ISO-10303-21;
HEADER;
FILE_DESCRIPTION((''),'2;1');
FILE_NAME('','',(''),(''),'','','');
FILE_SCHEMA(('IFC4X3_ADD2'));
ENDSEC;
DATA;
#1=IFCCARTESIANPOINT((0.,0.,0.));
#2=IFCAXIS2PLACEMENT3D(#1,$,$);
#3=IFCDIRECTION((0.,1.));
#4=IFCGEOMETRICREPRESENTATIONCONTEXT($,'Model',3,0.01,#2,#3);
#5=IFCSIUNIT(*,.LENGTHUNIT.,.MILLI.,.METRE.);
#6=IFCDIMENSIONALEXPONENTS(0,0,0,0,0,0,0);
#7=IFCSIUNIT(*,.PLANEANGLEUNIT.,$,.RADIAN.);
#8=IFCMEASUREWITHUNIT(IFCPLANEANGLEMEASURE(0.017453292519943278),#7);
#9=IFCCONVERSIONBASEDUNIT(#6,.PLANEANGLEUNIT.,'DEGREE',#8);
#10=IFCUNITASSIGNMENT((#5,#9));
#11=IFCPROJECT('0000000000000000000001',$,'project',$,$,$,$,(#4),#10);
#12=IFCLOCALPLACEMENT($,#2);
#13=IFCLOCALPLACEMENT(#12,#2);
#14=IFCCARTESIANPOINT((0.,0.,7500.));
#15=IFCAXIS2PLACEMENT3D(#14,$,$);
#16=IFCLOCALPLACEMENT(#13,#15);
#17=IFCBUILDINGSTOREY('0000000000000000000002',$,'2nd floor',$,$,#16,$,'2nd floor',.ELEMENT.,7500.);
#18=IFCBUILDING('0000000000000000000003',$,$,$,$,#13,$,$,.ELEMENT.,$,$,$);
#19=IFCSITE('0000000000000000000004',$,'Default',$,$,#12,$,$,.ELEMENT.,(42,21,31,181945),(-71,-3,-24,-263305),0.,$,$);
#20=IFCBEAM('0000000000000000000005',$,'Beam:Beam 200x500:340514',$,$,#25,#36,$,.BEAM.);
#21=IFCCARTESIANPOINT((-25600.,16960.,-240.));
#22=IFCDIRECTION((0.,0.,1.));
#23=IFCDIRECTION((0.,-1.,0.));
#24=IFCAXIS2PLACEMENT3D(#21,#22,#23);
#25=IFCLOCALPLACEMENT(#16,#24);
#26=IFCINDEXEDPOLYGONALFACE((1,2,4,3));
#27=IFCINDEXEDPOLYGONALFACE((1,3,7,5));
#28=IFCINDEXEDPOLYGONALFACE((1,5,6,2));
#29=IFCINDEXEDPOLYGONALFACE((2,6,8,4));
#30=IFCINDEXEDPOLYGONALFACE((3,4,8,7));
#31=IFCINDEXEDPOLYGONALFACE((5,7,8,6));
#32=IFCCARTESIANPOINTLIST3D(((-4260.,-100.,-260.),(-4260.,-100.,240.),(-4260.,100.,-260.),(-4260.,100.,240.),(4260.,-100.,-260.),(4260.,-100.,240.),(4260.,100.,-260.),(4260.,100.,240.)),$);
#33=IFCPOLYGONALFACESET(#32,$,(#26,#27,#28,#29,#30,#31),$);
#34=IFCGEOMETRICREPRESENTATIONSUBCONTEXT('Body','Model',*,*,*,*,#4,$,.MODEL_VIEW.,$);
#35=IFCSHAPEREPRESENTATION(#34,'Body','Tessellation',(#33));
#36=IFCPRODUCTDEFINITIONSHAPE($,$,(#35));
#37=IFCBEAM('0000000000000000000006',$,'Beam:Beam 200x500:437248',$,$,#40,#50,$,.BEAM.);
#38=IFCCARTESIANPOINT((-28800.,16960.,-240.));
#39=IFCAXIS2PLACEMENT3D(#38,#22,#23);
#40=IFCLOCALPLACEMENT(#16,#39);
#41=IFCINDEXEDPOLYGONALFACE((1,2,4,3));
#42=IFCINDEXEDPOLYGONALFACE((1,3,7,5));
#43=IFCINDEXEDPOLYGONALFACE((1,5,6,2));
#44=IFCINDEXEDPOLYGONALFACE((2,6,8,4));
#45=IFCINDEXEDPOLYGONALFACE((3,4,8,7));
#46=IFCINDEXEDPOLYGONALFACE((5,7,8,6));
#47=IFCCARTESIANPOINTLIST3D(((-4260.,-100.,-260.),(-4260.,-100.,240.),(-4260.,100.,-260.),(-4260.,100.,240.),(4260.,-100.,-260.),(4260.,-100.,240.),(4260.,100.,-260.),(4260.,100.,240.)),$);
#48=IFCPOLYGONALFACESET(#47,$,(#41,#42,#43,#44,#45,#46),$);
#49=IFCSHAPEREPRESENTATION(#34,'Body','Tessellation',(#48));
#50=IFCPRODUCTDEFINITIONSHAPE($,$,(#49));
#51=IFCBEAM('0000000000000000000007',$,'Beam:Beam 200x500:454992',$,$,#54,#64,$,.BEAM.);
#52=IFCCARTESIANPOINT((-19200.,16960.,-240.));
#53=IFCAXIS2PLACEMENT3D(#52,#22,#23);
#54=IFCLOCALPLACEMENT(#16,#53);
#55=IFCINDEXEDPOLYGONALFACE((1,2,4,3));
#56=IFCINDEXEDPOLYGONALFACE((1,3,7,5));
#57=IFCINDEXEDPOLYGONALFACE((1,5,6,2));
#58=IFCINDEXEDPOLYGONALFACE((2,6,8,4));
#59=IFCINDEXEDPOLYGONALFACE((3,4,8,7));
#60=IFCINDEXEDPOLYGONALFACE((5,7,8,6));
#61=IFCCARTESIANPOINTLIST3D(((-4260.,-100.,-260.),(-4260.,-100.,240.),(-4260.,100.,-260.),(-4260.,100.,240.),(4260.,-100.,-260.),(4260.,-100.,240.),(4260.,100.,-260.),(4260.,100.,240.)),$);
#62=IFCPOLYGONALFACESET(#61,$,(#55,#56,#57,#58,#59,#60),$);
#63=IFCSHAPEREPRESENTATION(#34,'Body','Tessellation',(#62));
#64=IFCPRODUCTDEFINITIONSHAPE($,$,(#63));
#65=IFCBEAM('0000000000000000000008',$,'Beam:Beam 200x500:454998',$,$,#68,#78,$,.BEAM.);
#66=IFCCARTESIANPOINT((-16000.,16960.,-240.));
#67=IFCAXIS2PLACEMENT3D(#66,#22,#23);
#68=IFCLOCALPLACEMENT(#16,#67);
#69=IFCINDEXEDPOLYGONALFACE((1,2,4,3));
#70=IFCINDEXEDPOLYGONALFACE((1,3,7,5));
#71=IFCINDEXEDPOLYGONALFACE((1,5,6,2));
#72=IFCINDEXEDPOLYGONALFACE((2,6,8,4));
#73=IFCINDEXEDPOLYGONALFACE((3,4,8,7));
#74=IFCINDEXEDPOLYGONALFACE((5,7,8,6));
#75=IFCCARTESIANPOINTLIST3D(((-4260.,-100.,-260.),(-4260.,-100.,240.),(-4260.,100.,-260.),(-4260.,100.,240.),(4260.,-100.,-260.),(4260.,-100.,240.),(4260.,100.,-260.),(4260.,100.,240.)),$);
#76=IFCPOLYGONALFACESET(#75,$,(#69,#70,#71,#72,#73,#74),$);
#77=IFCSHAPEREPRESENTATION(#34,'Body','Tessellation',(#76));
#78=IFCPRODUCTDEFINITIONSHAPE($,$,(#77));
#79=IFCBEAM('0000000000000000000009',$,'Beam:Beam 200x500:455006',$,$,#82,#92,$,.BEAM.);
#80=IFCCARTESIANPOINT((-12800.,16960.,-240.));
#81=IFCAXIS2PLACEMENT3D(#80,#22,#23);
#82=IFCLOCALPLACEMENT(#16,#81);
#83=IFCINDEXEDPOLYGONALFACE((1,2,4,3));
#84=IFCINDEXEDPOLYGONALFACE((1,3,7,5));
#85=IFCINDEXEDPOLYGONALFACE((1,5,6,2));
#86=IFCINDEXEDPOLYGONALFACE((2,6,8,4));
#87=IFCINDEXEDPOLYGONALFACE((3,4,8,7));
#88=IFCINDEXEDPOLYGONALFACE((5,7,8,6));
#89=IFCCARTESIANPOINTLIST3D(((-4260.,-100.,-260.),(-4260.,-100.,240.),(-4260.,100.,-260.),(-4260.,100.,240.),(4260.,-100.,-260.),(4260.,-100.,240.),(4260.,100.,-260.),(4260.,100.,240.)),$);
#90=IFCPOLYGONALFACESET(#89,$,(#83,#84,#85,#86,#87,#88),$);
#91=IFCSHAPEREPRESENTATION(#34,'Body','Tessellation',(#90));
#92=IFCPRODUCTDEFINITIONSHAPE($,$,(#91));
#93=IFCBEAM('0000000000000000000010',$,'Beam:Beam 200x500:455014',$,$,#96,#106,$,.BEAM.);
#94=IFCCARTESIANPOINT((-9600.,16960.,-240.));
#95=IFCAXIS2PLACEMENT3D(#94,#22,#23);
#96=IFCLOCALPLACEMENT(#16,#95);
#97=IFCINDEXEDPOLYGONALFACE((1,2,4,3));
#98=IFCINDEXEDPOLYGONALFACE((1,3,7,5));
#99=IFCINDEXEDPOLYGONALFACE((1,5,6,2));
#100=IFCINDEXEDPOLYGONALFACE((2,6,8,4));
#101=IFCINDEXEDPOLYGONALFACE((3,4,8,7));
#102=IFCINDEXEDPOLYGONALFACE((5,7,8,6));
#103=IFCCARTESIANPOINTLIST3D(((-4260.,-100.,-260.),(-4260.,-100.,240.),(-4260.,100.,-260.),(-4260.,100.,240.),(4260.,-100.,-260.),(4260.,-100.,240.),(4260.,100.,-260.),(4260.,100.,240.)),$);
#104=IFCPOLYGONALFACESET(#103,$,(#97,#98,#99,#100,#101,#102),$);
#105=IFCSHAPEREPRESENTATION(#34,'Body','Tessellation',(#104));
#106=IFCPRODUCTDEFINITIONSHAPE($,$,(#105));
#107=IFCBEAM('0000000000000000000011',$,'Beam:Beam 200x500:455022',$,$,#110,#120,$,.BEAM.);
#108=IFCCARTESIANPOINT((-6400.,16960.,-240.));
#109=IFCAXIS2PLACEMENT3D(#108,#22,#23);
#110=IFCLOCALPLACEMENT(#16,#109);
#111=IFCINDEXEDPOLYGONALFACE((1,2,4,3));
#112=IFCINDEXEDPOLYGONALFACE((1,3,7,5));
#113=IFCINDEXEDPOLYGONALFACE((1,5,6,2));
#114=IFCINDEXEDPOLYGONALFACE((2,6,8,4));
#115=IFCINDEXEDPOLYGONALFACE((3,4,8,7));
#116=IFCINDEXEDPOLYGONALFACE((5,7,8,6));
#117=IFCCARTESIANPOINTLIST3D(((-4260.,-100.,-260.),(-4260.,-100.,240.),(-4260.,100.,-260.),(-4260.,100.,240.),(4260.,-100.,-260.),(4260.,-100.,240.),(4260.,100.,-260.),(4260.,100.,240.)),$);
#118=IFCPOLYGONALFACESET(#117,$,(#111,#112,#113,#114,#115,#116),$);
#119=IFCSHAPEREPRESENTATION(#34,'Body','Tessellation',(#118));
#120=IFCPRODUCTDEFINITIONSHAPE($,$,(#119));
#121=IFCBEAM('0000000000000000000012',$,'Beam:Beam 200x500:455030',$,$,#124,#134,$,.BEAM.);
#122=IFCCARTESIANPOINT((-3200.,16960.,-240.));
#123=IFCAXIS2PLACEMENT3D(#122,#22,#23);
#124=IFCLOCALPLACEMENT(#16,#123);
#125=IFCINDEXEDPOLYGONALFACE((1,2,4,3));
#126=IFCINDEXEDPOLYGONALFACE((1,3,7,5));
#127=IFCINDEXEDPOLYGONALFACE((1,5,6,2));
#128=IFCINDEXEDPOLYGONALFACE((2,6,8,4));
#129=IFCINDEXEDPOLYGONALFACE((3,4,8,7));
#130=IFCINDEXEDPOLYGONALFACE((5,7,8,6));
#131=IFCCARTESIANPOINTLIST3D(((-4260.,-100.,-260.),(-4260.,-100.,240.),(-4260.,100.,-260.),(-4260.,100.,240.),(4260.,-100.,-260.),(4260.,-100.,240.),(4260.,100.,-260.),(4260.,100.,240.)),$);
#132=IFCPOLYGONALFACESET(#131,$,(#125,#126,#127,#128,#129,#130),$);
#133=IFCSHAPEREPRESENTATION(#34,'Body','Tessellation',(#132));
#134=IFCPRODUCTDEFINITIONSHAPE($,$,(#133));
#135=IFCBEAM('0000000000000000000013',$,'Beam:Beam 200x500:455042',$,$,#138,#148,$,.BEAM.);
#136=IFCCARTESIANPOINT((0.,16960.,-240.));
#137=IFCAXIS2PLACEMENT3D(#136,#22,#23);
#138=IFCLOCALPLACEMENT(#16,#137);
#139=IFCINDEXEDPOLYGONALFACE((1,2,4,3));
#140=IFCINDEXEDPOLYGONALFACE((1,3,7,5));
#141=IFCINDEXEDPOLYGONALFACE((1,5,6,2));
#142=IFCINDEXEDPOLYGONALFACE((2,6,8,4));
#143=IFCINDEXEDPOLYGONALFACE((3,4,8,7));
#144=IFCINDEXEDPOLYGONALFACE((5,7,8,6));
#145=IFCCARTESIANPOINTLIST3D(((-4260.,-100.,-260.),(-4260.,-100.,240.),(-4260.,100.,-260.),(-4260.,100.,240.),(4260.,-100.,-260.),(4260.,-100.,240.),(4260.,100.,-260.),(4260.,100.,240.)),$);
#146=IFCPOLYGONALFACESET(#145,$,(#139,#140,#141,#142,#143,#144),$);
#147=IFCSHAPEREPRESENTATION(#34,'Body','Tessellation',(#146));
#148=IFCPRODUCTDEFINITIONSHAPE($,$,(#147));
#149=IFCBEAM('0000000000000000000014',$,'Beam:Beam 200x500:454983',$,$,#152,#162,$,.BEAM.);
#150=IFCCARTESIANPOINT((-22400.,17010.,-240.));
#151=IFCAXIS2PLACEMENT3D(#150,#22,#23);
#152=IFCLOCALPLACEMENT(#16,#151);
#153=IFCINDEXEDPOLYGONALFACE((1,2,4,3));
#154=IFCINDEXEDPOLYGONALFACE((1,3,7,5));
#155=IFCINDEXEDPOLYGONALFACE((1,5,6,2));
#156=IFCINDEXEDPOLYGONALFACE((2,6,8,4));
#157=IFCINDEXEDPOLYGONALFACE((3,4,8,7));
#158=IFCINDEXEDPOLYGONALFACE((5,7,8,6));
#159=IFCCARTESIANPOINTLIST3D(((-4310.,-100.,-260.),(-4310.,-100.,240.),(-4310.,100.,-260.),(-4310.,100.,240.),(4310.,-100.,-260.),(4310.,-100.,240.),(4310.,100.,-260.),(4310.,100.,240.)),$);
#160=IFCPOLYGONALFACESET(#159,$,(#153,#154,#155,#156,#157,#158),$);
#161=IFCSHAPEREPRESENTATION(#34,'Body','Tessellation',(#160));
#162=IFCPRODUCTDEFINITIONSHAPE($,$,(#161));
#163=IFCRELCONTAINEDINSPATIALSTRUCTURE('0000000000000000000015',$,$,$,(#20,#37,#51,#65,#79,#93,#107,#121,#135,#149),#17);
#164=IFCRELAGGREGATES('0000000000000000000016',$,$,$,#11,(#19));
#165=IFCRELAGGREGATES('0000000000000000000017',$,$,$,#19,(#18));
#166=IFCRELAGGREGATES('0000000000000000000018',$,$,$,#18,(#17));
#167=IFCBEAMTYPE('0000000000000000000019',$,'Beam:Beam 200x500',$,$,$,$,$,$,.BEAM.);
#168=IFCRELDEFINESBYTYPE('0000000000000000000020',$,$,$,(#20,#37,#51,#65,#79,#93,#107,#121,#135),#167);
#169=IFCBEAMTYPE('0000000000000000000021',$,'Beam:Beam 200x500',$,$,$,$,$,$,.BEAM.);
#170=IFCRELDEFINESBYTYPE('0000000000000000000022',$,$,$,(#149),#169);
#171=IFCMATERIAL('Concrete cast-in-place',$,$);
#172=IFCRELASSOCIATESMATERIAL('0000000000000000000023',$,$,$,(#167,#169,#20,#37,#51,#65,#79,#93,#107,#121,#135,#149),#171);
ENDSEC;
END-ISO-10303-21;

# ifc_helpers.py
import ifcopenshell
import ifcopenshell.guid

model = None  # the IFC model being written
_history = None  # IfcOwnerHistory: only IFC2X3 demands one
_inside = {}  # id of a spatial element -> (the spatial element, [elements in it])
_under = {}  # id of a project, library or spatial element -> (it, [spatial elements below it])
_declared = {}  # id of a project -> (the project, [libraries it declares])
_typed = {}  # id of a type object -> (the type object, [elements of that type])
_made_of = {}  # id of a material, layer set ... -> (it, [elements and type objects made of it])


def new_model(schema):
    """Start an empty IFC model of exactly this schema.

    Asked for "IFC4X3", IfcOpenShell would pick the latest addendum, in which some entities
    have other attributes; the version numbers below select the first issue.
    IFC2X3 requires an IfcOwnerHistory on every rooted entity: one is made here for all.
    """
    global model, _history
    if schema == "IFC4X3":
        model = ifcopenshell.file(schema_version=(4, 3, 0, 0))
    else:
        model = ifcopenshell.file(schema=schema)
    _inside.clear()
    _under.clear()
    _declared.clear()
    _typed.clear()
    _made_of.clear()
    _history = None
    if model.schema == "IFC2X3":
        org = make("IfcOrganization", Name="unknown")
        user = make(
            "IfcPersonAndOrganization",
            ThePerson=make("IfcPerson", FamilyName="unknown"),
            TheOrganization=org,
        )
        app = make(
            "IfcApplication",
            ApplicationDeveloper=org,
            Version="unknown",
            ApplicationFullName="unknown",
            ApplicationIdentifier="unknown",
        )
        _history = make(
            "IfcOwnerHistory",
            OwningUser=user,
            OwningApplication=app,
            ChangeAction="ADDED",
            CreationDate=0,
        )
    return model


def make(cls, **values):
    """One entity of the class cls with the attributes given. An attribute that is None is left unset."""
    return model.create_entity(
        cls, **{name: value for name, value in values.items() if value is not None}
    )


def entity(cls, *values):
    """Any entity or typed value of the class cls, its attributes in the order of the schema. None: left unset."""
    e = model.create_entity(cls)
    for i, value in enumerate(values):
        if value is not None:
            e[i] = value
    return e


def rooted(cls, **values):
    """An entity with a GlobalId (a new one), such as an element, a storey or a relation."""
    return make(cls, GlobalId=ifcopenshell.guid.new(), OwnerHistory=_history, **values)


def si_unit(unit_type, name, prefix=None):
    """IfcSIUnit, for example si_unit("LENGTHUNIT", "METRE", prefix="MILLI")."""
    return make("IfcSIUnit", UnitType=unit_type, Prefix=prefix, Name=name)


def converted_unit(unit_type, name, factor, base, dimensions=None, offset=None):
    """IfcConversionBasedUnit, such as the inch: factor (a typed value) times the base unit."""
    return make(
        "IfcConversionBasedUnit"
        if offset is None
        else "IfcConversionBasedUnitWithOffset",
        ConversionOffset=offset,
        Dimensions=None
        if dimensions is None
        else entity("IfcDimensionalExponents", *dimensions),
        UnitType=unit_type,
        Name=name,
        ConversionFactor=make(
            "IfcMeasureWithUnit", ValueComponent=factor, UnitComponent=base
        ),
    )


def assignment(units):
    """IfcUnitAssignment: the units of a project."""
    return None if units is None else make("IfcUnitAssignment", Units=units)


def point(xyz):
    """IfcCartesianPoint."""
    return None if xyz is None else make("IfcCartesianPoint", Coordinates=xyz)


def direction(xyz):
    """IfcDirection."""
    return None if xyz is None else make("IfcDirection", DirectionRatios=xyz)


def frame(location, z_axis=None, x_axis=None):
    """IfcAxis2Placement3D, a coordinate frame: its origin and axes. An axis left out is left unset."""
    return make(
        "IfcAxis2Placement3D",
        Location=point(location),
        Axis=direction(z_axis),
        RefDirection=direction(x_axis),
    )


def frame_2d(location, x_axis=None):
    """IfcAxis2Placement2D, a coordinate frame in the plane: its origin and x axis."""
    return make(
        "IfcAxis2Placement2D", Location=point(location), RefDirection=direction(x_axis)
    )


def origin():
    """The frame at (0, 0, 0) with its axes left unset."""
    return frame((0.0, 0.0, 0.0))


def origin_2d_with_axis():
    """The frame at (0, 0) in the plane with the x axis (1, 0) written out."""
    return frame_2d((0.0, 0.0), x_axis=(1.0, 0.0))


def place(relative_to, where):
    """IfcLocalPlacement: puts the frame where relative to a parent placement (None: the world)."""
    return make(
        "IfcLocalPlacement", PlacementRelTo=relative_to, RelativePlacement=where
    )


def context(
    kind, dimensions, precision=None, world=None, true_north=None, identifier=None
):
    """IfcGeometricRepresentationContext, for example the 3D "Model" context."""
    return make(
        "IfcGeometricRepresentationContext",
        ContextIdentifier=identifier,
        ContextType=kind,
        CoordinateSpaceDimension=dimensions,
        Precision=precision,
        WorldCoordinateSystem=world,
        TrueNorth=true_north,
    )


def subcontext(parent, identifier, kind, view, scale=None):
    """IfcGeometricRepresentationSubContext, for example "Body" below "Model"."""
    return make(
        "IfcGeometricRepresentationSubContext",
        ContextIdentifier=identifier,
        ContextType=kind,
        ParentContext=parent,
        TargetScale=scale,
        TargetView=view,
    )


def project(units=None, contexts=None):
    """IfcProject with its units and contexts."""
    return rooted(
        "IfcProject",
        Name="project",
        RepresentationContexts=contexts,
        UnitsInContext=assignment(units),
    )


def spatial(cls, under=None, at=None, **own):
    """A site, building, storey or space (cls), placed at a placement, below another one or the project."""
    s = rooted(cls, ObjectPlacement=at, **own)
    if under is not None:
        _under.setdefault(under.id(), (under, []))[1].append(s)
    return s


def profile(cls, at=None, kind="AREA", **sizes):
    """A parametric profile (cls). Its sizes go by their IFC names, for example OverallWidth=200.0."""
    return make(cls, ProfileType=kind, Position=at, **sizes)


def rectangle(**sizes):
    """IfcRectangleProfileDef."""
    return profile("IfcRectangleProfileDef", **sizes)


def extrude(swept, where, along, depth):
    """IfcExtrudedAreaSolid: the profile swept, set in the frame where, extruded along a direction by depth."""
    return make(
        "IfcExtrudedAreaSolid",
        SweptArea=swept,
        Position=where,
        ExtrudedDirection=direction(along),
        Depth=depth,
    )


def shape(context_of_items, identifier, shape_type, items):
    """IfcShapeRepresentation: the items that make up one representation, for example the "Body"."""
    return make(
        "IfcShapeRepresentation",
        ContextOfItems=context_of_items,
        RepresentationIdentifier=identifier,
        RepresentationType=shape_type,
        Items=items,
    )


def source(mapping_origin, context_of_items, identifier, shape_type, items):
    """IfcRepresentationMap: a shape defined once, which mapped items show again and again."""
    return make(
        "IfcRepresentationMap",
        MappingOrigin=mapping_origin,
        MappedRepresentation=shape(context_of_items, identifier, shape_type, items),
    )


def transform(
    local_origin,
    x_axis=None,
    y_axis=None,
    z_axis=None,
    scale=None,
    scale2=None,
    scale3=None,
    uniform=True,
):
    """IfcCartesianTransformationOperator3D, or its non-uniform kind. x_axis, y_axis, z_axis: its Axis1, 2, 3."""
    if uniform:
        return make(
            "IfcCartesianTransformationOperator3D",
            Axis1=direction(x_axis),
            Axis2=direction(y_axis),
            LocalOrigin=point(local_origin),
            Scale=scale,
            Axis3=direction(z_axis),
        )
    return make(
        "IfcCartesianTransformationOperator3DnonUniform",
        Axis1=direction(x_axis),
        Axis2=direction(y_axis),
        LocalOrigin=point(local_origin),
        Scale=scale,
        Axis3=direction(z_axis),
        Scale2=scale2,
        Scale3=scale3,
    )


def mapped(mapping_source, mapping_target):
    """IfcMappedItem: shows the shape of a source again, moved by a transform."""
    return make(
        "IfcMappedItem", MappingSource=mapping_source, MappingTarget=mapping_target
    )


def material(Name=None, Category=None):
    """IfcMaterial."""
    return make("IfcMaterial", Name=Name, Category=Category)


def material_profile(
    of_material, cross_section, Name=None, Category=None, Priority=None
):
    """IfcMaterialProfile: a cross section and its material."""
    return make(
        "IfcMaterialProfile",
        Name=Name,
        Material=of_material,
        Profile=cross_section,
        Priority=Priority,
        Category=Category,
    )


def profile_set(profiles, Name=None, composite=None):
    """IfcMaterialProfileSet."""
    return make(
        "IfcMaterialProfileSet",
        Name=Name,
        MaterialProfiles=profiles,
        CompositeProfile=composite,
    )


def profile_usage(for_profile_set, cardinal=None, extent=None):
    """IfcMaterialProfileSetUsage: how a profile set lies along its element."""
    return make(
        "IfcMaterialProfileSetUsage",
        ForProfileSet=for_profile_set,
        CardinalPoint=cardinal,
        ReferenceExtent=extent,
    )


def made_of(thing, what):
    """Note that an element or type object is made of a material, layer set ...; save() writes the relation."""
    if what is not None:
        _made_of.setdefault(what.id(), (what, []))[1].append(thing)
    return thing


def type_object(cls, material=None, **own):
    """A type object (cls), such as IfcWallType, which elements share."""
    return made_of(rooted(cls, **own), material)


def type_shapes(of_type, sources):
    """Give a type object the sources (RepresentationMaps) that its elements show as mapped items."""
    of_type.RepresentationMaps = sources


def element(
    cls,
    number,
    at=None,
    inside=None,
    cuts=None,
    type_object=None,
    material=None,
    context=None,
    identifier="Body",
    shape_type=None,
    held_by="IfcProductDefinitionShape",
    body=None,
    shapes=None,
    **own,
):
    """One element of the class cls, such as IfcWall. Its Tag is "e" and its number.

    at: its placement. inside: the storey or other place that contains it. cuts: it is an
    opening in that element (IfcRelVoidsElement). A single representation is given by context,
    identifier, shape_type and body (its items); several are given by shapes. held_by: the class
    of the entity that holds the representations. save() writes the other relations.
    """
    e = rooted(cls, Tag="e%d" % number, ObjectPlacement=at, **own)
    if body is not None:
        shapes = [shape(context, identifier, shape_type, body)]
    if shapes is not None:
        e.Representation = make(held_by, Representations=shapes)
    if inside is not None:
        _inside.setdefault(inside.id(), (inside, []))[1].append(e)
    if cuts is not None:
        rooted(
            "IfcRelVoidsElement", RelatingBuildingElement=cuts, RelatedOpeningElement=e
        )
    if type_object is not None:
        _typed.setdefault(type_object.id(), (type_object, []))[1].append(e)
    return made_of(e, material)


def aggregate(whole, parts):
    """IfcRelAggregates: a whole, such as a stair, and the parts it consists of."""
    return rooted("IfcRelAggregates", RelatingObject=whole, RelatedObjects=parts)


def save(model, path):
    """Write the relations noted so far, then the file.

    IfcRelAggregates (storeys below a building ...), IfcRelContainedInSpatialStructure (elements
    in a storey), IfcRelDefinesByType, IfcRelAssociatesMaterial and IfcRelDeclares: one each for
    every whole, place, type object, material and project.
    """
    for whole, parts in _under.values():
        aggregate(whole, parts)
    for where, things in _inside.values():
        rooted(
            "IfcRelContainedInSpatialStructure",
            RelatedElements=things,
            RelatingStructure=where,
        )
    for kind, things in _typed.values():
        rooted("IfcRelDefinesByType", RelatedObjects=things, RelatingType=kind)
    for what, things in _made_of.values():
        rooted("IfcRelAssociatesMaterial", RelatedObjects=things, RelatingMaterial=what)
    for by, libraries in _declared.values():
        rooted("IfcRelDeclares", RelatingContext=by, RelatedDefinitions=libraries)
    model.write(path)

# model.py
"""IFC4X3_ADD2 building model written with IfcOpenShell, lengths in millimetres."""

from ifc_helpers import new_model, entity, si_unit, converted_unit, direction, frame, origin, origin_2d_with_axis, place, context, subcontext, project, spatial, rectangle, extrude, source, transform, mapped, material, material_profile, profile_set, profile_usage, type_object, type_shapes, element, save


model = new_model("IFC4X3_ADD2")

# Units and contexts
model_context = context("Model", 3, precision=0.01, world=origin(), true_north=direction((0.0, 1.0)))
body_context = subcontext(model_context, "Body", "Model", "MODEL_VIEW")
ifc_project = project(units=[si_unit("LENGTHUNIT", "METRE", prefix="MILLI"), converted_unit("PLANEANGLEUNIT", "DEGREE", entity("IfcPlaneAngleMeasure", 0.017453292519943278), si_unit("PLANEANGLEUNIT", "RADIAN"), dimensions=[0, 0, 0, 0, 0, 0, 0])], contexts=[model_context])

# Site, building, storey
site_placement = place(None, origin())
site = spatial("IfcSite", under=ifc_project, at=site_placement, Name="Default", CompositionType="ELEMENT", RefLatitude=(42, 21, 31, 181945), RefLongitude=(-71, -3, -24, -263305), RefElevation=0.0)
building_placement = place(site_placement, origin())
building = spatial("IfcBuilding", under=site, at=building_placement, CompositionType="ELEMENT")
storey_placement = place(building_placement, frame((0.0, 0.0, 7500.0)))
storey = spatial("IfcBuildingStorey", under=building, at=storey_placement, Name="2nd floor", LongName="2nd floor", CompositionType="ELEMENT", Elevation=7500.0)

# Beams
ifc_material_1 = material(Name="Concrete cast-in-place")
ifc_material_profile_1 = material_profile(ifc_material_1, rectangle(XDim=8600.0, YDim=200.0, at=origin_2d_with_axis()), Name="Beam 200x500")
ifc_profile_set_1 = profile_set([ifc_material_profile_1], Name="Beam 200x500")
ifc_profile_usage_1 = profile_usage(ifc_profile_set_1, cardinal=8)
beam_type_1 = type_object("IfcBeamType", Name="Beam:Beam 200x500", PredefinedType="BEAM", material=ifc_profile_set_1)
shared_shape_1 = source(origin(), body_context, "Body", "SweptSolid", [
    extrude(rectangle(XDim=8520.0, YDim=200.0, at=origin_2d_with_axis()), frame((0.0, 0.0, -260.0), z_axis=(0.0, 0.0, 1.0), x_axis=(-1.0, 0.0, 0.0)), (0.0, 0.0, 1.0), 500.0),
])
type_shapes(beam_type_1, [shared_shape_1])
for number, where, z_axis, x_axis, name in (
    (1, (-25600.0, 16960.0, -240.0), (0.0, 0.0, 1.0), (0.0, -1.0, 0.0), "Beam:Beam 200x500:340514"),
    (2, (-28800.0, 16960.0, -240.0), (0.0, 0.0, 1.0), (0.0, -1.0, 0.0), "Beam:Beam 200x500:437248"),
    (3, (-19200.0, 16960.0, -240.0), (0.0, 0.0, 1.0), (0.0, -1.0, 0.0), "Beam:Beam 200x500:454992"),
    (4, (-16000.0, 16960.0, -240.0), (0.0, 0.0, 1.0), (0.0, -1.0, 0.0), "Beam:Beam 200x500:454998"),
    (5, (-12800.0, 16960.0, -240.0), (0.0, 0.0, 1.0), (0.0, -1.0, 0.0), "Beam:Beam 200x500:455006"),
    (6, (-9600.0, 16960.0, -240.0), (0.0, 0.0, 1.0), (0.0, -1.0, 0.0), "Beam:Beam 200x500:455014"),
    (7, (-6400.0, 16960.0, -240.0), (0.0, 0.0, 1.0), (0.0, -1.0, 0.0), "Beam:Beam 200x500:455022"),
    (8, (-3200.0, 16960.0, -240.0), (0.0, 0.0, 1.0), (0.0, -1.0, 0.0), "Beam:Beam 200x500:455030"),
    (9, (0.0, 16960.0, -240.0), (0.0, 0.0, 1.0), (0.0, -1.0, 0.0), "Beam:Beam 200x500:455042"),
):
    element("IfcBeam", number, at=place(storey_placement, frame(where, z_axis=z_axis, x_axis=x_axis)), inside=storey, type_object=beam_type_1, material=ifc_profile_usage_1, Name=name, PredefinedType="BEAM", context=body_context, shape_type="MappedRepresentation", body=[
        mapped(shared_shape_1, transform((0.0, 0.0, 0.0), scale=1.0)),
    ])
beam_type_2 = type_object("IfcBeamType", Name="Beam:Beam 200x500", PredefinedType="BEAM", material=ifc_profile_set_1)
shared_shape_2 = source(origin(), body_context, "Body", "SweptSolid", [
    extrude(rectangle(XDim=8620.0, YDim=200.0, at=origin_2d_with_axis()), frame((0.0, 0.0, -260.0), z_axis=(0.0, 0.0, 1.0), x_axis=(-1.0, 0.0, 0.0)), (0.0, 0.0, 1.0), 500.0),
])
type_shapes(beam_type_2, [shared_shape_2])
beam_1_placement = place(storey_placement, frame((-22400.0, 17010.0, -240.0), z_axis=(0.0, 0.0, 1.0), x_axis=(0.0, -1.0, 0.0)))
element("IfcBeam", 10, at=beam_1_placement, inside=storey, type_object=beam_type_2, material=ifc_profile_usage_1, Name="Beam:Beam 200x500:454983", PredefinedType="BEAM", context=body_context, shape_type="MappedRepresentation", body=[
    mapped(shared_shape_2, transform((0.0, 0.0, 0.0), scale=1.0)),
])

save(model, "model.ifc")
